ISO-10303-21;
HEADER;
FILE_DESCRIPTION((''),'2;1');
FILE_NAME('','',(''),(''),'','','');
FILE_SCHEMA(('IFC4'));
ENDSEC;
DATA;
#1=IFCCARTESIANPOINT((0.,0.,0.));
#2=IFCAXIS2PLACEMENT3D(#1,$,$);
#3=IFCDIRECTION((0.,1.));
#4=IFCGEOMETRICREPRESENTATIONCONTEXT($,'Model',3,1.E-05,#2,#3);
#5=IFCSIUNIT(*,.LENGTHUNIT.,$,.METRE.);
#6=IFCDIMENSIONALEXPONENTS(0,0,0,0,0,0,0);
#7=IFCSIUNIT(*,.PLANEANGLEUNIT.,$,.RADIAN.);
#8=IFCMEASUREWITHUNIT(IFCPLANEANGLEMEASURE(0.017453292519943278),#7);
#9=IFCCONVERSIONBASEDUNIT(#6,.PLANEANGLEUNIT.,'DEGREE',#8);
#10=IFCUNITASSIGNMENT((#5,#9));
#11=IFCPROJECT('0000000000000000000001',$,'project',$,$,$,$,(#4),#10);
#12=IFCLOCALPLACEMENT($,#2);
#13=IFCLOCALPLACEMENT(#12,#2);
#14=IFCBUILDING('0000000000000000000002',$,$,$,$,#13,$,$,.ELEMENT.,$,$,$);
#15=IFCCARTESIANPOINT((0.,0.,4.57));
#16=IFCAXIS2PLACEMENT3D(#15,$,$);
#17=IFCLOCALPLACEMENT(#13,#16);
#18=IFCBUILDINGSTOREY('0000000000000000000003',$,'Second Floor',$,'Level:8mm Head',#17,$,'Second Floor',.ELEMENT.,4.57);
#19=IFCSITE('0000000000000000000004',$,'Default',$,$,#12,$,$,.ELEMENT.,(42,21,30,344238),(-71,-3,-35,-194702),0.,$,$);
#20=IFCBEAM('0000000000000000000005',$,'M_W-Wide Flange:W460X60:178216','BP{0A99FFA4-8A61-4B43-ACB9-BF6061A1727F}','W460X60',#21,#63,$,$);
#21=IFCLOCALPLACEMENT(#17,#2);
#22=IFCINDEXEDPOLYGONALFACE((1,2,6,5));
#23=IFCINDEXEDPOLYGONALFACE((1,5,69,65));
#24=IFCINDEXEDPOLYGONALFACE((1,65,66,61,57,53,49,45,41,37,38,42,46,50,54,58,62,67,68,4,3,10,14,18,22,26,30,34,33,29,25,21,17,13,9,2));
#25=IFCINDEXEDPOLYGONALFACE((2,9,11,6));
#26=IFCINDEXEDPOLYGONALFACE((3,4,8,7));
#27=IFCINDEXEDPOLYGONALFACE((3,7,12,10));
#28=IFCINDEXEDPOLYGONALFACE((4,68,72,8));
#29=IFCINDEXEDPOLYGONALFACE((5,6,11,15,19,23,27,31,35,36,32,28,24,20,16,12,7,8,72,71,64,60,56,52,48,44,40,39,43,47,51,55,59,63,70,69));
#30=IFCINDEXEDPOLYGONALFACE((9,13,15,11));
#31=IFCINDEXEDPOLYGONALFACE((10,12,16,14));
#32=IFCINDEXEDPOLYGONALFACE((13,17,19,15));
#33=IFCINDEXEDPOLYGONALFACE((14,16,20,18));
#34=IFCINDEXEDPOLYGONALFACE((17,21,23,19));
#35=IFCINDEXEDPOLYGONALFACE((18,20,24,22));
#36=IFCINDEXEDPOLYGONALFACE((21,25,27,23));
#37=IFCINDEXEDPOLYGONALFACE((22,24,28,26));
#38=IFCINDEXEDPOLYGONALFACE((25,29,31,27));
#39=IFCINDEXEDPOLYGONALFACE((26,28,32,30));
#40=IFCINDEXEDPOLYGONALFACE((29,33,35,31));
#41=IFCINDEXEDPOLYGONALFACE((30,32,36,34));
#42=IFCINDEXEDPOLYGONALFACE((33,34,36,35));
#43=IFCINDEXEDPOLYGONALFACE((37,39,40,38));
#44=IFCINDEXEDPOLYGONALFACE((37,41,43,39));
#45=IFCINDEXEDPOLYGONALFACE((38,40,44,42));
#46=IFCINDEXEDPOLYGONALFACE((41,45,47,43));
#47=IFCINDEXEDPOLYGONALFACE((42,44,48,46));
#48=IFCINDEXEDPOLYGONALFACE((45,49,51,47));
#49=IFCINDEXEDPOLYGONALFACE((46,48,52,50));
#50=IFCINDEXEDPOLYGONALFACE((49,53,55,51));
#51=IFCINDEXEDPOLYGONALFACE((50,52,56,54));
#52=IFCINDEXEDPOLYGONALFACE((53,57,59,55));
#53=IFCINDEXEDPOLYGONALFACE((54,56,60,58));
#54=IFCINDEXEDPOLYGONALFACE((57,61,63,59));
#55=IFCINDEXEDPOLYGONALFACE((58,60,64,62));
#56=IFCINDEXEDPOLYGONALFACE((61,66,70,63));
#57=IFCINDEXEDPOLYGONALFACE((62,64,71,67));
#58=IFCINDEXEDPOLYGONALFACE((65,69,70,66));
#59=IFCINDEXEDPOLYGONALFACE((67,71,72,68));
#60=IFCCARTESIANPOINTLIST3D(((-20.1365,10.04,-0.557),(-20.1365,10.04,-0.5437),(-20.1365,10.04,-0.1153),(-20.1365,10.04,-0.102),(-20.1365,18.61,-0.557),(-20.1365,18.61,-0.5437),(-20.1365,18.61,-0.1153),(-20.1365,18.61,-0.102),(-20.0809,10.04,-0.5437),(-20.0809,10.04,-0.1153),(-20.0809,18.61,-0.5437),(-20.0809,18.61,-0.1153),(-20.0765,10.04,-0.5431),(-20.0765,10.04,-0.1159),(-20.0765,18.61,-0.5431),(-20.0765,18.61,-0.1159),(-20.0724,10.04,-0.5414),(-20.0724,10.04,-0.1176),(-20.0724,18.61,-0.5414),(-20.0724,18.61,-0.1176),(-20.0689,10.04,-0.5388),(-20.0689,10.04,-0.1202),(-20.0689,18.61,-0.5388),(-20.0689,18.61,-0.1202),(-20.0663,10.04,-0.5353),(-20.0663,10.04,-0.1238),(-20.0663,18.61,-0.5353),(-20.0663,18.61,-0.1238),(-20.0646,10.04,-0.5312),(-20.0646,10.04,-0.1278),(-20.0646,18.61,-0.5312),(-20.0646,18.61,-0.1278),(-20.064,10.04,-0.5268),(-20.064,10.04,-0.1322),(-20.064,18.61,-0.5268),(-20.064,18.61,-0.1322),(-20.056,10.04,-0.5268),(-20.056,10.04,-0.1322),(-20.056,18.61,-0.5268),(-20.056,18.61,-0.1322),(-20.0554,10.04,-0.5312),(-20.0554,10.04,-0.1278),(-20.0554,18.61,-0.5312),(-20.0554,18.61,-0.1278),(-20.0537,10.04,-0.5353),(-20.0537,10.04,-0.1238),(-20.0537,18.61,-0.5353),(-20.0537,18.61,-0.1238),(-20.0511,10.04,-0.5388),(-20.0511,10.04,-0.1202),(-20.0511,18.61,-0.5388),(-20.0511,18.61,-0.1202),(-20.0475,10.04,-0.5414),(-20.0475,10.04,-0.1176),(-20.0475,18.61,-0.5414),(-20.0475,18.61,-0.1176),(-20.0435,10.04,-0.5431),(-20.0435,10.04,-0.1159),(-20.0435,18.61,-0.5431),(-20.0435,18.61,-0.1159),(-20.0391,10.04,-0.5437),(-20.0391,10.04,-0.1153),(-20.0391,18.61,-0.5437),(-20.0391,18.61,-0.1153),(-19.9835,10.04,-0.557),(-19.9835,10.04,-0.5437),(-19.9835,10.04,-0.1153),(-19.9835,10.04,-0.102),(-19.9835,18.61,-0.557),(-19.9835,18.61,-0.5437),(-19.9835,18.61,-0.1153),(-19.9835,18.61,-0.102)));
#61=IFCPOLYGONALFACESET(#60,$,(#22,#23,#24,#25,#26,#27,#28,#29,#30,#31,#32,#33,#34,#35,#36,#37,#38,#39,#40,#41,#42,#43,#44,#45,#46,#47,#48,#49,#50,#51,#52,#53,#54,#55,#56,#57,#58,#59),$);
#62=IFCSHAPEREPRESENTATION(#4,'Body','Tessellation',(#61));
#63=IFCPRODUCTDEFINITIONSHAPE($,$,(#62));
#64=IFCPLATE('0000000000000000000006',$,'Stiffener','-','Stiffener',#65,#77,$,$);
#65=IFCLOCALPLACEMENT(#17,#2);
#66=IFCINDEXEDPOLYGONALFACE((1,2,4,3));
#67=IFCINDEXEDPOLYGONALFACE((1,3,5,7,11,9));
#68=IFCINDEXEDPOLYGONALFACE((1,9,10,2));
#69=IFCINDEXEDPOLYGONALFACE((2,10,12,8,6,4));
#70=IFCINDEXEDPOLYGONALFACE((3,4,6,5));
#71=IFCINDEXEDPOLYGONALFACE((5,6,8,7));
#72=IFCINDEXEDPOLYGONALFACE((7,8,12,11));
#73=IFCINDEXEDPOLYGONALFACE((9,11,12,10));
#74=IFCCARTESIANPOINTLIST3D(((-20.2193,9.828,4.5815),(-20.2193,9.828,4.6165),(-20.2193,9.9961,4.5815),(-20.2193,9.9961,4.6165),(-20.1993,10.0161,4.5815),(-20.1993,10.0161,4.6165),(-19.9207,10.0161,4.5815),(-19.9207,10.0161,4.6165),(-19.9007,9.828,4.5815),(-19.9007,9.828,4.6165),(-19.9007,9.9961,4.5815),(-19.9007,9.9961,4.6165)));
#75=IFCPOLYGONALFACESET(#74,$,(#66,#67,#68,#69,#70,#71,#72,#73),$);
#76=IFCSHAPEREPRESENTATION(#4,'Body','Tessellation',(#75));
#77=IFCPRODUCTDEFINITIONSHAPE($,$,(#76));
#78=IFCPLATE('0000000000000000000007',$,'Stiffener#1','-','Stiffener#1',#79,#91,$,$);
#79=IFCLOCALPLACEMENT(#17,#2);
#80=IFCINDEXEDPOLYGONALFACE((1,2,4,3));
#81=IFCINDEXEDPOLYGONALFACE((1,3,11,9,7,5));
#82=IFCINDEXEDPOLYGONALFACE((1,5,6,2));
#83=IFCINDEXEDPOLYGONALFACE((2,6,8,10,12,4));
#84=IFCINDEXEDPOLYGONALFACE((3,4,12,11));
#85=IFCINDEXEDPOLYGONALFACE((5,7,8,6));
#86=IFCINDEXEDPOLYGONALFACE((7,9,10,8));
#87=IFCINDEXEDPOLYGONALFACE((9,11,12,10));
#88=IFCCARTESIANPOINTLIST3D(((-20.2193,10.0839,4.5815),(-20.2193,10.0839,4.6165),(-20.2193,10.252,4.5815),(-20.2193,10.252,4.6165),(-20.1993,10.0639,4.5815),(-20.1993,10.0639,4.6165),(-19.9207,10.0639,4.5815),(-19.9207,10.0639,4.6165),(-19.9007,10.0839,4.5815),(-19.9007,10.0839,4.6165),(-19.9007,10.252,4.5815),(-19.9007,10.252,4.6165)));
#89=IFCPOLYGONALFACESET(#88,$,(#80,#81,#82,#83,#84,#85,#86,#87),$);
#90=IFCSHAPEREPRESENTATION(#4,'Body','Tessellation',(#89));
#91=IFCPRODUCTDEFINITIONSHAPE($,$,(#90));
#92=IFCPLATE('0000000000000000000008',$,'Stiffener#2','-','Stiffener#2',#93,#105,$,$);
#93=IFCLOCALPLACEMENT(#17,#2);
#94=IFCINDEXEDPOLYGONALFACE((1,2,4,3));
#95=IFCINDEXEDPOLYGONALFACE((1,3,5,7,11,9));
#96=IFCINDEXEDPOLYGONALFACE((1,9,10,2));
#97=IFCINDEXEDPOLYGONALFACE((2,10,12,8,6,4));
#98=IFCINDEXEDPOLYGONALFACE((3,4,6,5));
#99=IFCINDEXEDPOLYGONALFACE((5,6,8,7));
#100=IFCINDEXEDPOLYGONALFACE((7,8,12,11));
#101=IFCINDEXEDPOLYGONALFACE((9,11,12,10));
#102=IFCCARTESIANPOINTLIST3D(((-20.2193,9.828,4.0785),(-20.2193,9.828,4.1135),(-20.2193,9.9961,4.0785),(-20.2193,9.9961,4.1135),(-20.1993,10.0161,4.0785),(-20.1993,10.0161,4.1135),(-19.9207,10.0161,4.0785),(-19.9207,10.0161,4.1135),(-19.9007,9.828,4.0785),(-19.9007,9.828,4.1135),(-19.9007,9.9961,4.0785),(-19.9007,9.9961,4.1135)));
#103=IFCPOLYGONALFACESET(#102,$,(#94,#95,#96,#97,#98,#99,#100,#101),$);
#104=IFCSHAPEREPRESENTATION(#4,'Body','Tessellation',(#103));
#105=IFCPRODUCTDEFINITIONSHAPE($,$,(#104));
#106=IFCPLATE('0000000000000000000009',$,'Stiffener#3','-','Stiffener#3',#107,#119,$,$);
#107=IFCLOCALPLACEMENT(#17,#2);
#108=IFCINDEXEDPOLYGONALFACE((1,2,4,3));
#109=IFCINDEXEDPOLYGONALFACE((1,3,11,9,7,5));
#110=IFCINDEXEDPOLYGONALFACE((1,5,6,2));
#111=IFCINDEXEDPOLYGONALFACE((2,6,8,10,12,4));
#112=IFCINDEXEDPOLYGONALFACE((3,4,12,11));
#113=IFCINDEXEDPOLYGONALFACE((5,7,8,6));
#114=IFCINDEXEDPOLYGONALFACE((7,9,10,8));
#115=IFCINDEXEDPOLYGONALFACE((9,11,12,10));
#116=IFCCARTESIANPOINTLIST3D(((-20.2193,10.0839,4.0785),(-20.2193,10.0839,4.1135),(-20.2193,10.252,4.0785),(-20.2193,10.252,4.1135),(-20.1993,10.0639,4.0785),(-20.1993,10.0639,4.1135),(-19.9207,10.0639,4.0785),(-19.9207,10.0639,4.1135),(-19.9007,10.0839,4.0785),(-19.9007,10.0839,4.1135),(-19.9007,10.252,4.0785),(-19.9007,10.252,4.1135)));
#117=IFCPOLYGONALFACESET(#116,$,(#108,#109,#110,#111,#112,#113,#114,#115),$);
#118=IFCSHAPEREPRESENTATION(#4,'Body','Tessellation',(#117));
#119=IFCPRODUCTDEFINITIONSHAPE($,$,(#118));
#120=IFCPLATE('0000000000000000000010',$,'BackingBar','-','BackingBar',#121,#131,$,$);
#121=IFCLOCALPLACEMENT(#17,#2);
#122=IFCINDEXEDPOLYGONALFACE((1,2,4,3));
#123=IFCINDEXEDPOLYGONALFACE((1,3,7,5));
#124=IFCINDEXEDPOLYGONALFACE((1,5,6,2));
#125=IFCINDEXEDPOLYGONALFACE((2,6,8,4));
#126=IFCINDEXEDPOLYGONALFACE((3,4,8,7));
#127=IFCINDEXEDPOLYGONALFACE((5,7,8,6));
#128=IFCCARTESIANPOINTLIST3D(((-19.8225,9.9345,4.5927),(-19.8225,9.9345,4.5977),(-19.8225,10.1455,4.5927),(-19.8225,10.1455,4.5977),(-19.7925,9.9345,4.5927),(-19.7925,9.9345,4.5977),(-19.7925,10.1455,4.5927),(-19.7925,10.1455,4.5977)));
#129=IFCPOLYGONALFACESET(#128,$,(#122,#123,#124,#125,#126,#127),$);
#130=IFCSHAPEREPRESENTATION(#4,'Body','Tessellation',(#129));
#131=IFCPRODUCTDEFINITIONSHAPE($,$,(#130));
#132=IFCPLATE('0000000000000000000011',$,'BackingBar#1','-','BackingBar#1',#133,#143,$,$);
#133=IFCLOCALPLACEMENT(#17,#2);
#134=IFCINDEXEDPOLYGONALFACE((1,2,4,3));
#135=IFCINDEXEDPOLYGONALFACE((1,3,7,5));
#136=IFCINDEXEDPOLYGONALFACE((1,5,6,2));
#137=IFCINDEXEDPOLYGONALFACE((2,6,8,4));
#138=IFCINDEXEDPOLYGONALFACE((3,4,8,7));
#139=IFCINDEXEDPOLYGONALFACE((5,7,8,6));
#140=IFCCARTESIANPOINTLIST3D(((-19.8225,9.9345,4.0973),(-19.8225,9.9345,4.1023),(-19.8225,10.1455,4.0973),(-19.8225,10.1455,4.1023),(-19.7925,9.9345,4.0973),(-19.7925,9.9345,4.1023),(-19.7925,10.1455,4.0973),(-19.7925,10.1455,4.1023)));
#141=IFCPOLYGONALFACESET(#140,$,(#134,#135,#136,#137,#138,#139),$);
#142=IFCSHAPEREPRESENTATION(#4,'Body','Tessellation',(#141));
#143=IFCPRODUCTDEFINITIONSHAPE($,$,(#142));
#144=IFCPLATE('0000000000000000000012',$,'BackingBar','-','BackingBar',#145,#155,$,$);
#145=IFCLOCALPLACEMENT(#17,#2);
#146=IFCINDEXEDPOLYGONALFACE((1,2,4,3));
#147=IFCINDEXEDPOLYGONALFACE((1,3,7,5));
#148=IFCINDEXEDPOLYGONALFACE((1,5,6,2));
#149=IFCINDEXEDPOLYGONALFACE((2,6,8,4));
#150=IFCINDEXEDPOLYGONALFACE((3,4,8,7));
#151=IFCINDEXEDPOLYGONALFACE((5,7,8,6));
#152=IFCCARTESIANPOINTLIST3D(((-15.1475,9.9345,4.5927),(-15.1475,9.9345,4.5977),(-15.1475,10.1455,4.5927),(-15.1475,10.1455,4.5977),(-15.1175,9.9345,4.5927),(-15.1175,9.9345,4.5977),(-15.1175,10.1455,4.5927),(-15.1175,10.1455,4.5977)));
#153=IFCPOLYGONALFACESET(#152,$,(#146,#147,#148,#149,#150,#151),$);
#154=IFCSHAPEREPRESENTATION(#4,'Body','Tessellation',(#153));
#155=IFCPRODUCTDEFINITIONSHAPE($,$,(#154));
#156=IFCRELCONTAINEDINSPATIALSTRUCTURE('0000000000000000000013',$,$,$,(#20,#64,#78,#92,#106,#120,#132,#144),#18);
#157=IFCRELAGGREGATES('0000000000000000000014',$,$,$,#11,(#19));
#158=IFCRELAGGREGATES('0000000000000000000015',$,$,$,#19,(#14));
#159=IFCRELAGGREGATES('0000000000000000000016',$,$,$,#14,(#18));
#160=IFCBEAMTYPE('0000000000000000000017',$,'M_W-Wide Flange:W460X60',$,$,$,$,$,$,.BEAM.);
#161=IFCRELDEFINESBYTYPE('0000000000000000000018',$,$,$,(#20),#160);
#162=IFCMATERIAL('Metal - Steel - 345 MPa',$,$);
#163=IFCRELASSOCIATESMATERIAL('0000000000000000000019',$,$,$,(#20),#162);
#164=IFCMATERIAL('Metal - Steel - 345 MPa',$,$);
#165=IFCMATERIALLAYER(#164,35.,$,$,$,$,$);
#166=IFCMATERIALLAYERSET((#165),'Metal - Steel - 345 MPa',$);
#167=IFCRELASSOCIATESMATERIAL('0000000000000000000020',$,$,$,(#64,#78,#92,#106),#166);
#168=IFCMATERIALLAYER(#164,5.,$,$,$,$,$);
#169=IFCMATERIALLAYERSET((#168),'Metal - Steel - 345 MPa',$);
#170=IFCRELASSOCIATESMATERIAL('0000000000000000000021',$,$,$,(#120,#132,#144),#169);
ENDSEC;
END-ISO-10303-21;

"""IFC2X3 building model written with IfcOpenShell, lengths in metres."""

from ifc_helpers import new_model, entity, si_unit, converted_unit, direction, frame, origin, origin_with_axes, origin_2d, place, context, project, spatial, polyline, i_section, outline, extrude, material, layer, layer_set, type_object, element, save


model = new_model("IFC2X3")

# Units and contexts
model_context = context("Model", 3, precision=1e-05, world=origin(), true_north=direction((0.0, 1.0)))
ifc_project = project(units=[si_unit("LENGTHUNIT", "METRE"), converted_unit("PLANEANGLEUNIT", "DEGREE", entity("IfcPlaneAngleMeasure", 0.017453292519943278), si_unit("PLANEANGLEUNIT", "RADIAN"), dimensions=[0, 0, 0, 0, 0, 0, 0])], contexts=[model_context])

# Site, building, storey
site_placement = place(None, origin())
site = spatial("IfcSite", under=ifc_project, at=site_placement, Name="Default", CompositionType="ELEMENT", RefLatitude=(42, 21, 30, 344238), RefLongitude=(-71, -3, -35, -194702), RefElevation=0.0)
building_placement = place(site_placement, origin())
building = spatial("IfcBuilding", under=site, at=building_placement, CompositionType="ELEMENT")
storey_placement = place(building_placement, frame((0.0, 0.0, 4.57)))
storey = spatial("IfcBuildingStorey", under=building, at=storey_placement, Name="Second Floor", ObjectType="Level:8mm Head", LongName="Second Floor", CompositionType="ELEMENT", Elevation=4.57)

# Shared definitions
ifc_material_1 = material(Name="Metal - Steel - 345 MPa")

# Beam
beam_type_1 = type_object("IfcBeamType", Name="M_W-Wide Flange:W460X60", PredefinedType="BEAM")
beam_1_placement = place(storey_placement, frame((-20.06, 10.04, -0.3295), z_axis=(0.0, -1.0, 0.0), x_axis=(1.0, 0.0, 0.0)))
element("IfcBeam", 1, at=beam_1_placement, inside=storey, type_object=beam_type_1, material=ifc_material_1, Name="M_W-Wide Flange:W460X60:178216", Description="BP{0A99FFA4-8A61-4B43-ACB9-BF6061A1727F}", ObjectType="W460X60", context=model_context, shape_type="SweptSolid", body=[
    extrude(i_section(OverallWidth=0.153, OverallDepth=0.455, WebThickness=0.008, FlangeThickness=0.0133, FilletRadius=0.0169, at=origin_2d()), origin(), (0.0, 0.0, -1.0), 8.57),
])

# Plates, openings
ifc_material_2 = material(Name="Metal - Steel - 345 MPa")
ifc_layer_1 = layer(ifc_material_2, 35.0)
ifc_layer_set_1 = layer_set([ifc_layer_1], Name="Metal - Steel - 345 MPa")
plate_1_placement = place(storey_placement, frame((-20.2193, 10.0161, 4.5815), z_axis=(0.0, 0.0, 1.0), x_axis=(0.0, -1.0, 0.0)))
plate_1 = element("IfcPlate", 2, at=plate_1_placement, inside=storey, material=ifc_layer_set_1, Name="Stiffener", Description="-", ObjectType="Stiffener", context=model_context, shape_type="SweptSolid", body=[
    extrude(outline(polyline([(0.0, 0.0), (0.1881, 0.0), (0.1881, 0.3186), (0.0, 0.3186), (0.0, 0.0)])), origin_with_axes(), (0.0, 0.0, 1.0), 0.035),
])
opening_1_placement = place(plate_1_placement, frame((0.0, 0.0, 0.0), z_axis=(0.0, 0.0, 1.0), x_axis=(1.0, 0.0, 0.0)))
element("IfcOpeningElement", 3, at=opening_1_placement, cuts=plate_1, ObjectType="Opening", context=model_context, shape_type="SweptSolid", body=[
    extrude(outline(polyline([(0.0, 0.3186), (0.0, 0.2986), (0.02, 0.3186), (0.0, 0.3186)])), origin(), (0.0, 0.0, 1.0), 0.035),
])
opening_2_placement = place(plate_1_placement, frame((0.0, 0.0, 0.0), z_axis=(0.0, 0.0, 1.0), x_axis=(1.0, 0.0, 0.0)))
element("IfcOpeningElement", 4, at=opening_2_placement, cuts=plate_1, ObjectType="Opening", context=model_context, shape_type="SweptSolid", body=[
    extrude(outline(polyline([(0.0, 0.0), (0.02, 0.0), (0.0, 0.02), (0.0, 0.0)])), origin(), (0.0, 0.0, 1.0), 0.035),
])
plate_2_placement = place(storey_placement, frame((-20.2193, 10.252, 4.5815), z_axis=(0.0, 0.0, 1.0), x_axis=(0.0, -1.0, 0.0)))
plate_2 = element("IfcPlate", 5, at=plate_2_placement, inside=storey, material=ifc_layer_set_1, Name="Stiffener#1", Description="-", ObjectType="Stiffener#1", context=model_context, shape_type="SweptSolid", body=[
    extrude(outline(polyline([(0.0, 0.0), (0.1881, 0.0), (0.1881, 0.3186), (0.0, 0.3186), (0.0, 0.0)])), origin_with_axes(), (0.0, 0.0, 1.0), 0.035),
])
opening_3_placement = place(plate_2_placement, frame((0.0, 0.0, 0.0), z_axis=(0.0, 0.0, 1.0), x_axis=(1.0, 0.0, 0.0)))
element("IfcOpeningElement", 6, at=opening_3_placement, cuts=plate_2, ObjectType="Opening", context=model_context, shape_type="SweptSolid", body=[
    extrude(outline(polyline([(0.1881, 0.3186), (0.1681, 0.3186), (0.1881, 0.2986), (0.1881, 0.3186)])), origin(), (0.0, 0.0, 1.0), 0.035),
])
opening_4_placement = place(plate_2_placement, frame((0.0, 0.0, 0.0), z_axis=(0.0, 0.0, 1.0), x_axis=(1.0, 0.0, 0.0)))
element("IfcOpeningElement", 7, at=opening_4_placement, cuts=plate_2, ObjectType="Opening", context=model_context, shape_type="SweptSolid", body=[
    extrude(outline(polyline([(0.1881, 0.0), (0.1881, 0.02), (0.1681, 0.0), (0.1881, 0.0)])), origin(), (0.0, 0.0, 1.0), 0.035),
])
plate_3_placement = place(storey_placement, frame((-20.2193, 9.828, 4.1135), z_axis=(0.0, 0.0, -1.0), x_axis=(0.0, 1.0, 0.0)))
plate_3 = element("IfcPlate", 8, at=plate_3_placement, inside=storey, material=ifc_layer_set_1, Name="Stiffener#2", Description="-", ObjectType="Stiffener#2", context=model_context, shape_type="SweptSolid", body=[
    extrude(outline(polyline([(0.0, 0.0), (0.1881, 0.0), (0.1881, 0.3186), (0.0, 0.3186), (0.0, 0.0)])), origin_with_axes(), (0.0, 0.0, 1.0), 0.035),
])
opening_5_placement = place(plate_3_placement, frame((0.0, 0.0, 0.0), z_axis=(0.0, 0.0, 1.0), x_axis=(1.0, 0.0, 0.0)))
element("IfcOpeningElement", 9, at=opening_5_placement, cuts=plate_3, ObjectType="Opening", context=model_context, shape_type="SweptSolid", body=[
    extrude(outline(polyline([(0.1881, 0.3186), (0.1681, 0.3186), (0.1881, 0.2986), (0.1881, 0.3186)])), origin(), (0.0, 0.0, 1.0), 0.035),
])
opening_6_placement = place(plate_3_placement, frame((0.0, 0.0, 0.0), z_axis=(0.0, 0.0, 1.0), x_axis=(1.0, 0.0, 0.0)))
element("IfcOpeningElement", 10, at=opening_6_placement, cuts=plate_3, ObjectType="Opening", context=model_context, shape_type="SweptSolid", body=[
    extrude(outline(polyline([(0.1881, 0.0), (0.1881, 0.02), (0.1681, 0.0), (0.1881, 0.0)])), origin(), (0.0, 0.0, 1.0), 0.035),
])
plate_4_placement = place(storey_placement, frame((-20.2193, 10.0639, 4.1135), z_axis=(0.0, 0.0, -1.0), x_axis=(0.0, 1.0, 0.0)))
plate_4 = element("IfcPlate", 11, at=plate_4_placement, inside=storey, material=ifc_layer_set_1, Name="Stiffener#3", Description="-", ObjectType="Stiffener#3", context=model_context, shape_type="SweptSolid", body=[
    extrude(outline(polyline([(0.0, 0.0), (0.1881, 0.0), (0.1881, 0.3186), (0.0, 0.3186), (0.0, 0.0)])), origin_with_axes(), (0.0, 0.0, 1.0), 0.035),
])
opening_7_placement = place(plate_4_placement, frame((0.0, 0.0, 0.0), z_axis=(0.0, 0.0, 1.0), x_axis=(1.0, 0.0, 0.0)))
element("IfcOpeningElement", 12, at=opening_7_placement, cuts=plate_4, ObjectType="Opening", context=model_context, shape_type="SweptSolid", body=[
    extrude(outline(polyline([(0.0, 0.3186), (0.0, 0.2986), (0.02, 0.3186), (0.0, 0.3186)])), origin(), (0.0, 0.0, 1.0), 0.035),
])
opening_8_placement = place(plate_4_placement, frame((0.0, 0.0, 0.0), z_axis=(0.0, 0.0, 1.0), x_axis=(1.0, 0.0, 0.0)))
element("IfcOpeningElement", 13, at=opening_8_placement, cuts=plate_4, ObjectType="Opening", context=model_context, shape_type="SweptSolid", body=[
    extrude(outline(polyline([(0.0, 0.0), (0.02, 0.0), (0.0, 0.02), (0.0, 0.0)])), origin(), (0.0, 0.0, 1.0), 0.035),
])

# Plates
ifc_layer_2 = layer(ifc_material_2, 5.0)
ifc_layer_set_2 = layer_set([ifc_layer_2], Name="Metal - Steel - 345 MPa")
plate_5_placement = place(storey_placement, frame((-19.8225, 10.1455, 4.5927), z_axis=(0.0, 0.0, 1.0), x_axis=(0.0, -1.0, 0.0)))
element("IfcPlate", 14, at=plate_5_placement, inside=storey, material=ifc_layer_set_2, Name="BackingBar", Description="-", ObjectType="BackingBar", context=model_context, shape_type="SweptSolid", body=[
    extrude(outline(polyline([(0.0, 0.0), (0.211, 0.0), (0.211, 0.03), (0.0, 0.03), (0.0, 0.0)])), origin_with_axes(), (0.0, 0.0, 1.0), 0.005),
])
plate_6_placement = place(storey_placement, frame((-19.8225, 9.9345, 4.1023), z_axis=(0.0, 0.0, -1.0), x_axis=(0.0, 1.0, 0.0)))
element("IfcPlate", 15, at=plate_6_placement, inside=storey, material=ifc_layer_set_2, Name="BackingBar#1", Description="-", ObjectType="BackingBar#1", context=model_context, shape_type="SweptSolid", body=[
    extrude(outline(polyline([(0.0, 0.0), (0.211, 0.0), (0.211, 0.03), (0.0, 0.03), (0.0, 0.0)])), origin_with_axes(), (0.0, 0.0, 1.0), 0.005),
])
plate_7_placement = place(storey_placement, frame((-15.1175, 9.9345, 4.5927), z_axis=(0.0, 0.0, 1.0), x_axis=(0.0, 1.0, 0.0)))
element("IfcPlate", 16, at=plate_7_placement, inside=storey, material=ifc_layer_set_2, Name="BackingBar", Description="-", ObjectType="BackingBar", context=model_context, shape_type="SweptSolid", body=[
    extrude(outline(polyline([(0.0, 0.0), (0.211, 0.0), (0.211, 0.03), (0.0, 0.03), (0.0, 0.0)])), origin_with_axes(), (0.0, 0.0, 1.0), 0.005),
])

save(model, "model.ifc")
